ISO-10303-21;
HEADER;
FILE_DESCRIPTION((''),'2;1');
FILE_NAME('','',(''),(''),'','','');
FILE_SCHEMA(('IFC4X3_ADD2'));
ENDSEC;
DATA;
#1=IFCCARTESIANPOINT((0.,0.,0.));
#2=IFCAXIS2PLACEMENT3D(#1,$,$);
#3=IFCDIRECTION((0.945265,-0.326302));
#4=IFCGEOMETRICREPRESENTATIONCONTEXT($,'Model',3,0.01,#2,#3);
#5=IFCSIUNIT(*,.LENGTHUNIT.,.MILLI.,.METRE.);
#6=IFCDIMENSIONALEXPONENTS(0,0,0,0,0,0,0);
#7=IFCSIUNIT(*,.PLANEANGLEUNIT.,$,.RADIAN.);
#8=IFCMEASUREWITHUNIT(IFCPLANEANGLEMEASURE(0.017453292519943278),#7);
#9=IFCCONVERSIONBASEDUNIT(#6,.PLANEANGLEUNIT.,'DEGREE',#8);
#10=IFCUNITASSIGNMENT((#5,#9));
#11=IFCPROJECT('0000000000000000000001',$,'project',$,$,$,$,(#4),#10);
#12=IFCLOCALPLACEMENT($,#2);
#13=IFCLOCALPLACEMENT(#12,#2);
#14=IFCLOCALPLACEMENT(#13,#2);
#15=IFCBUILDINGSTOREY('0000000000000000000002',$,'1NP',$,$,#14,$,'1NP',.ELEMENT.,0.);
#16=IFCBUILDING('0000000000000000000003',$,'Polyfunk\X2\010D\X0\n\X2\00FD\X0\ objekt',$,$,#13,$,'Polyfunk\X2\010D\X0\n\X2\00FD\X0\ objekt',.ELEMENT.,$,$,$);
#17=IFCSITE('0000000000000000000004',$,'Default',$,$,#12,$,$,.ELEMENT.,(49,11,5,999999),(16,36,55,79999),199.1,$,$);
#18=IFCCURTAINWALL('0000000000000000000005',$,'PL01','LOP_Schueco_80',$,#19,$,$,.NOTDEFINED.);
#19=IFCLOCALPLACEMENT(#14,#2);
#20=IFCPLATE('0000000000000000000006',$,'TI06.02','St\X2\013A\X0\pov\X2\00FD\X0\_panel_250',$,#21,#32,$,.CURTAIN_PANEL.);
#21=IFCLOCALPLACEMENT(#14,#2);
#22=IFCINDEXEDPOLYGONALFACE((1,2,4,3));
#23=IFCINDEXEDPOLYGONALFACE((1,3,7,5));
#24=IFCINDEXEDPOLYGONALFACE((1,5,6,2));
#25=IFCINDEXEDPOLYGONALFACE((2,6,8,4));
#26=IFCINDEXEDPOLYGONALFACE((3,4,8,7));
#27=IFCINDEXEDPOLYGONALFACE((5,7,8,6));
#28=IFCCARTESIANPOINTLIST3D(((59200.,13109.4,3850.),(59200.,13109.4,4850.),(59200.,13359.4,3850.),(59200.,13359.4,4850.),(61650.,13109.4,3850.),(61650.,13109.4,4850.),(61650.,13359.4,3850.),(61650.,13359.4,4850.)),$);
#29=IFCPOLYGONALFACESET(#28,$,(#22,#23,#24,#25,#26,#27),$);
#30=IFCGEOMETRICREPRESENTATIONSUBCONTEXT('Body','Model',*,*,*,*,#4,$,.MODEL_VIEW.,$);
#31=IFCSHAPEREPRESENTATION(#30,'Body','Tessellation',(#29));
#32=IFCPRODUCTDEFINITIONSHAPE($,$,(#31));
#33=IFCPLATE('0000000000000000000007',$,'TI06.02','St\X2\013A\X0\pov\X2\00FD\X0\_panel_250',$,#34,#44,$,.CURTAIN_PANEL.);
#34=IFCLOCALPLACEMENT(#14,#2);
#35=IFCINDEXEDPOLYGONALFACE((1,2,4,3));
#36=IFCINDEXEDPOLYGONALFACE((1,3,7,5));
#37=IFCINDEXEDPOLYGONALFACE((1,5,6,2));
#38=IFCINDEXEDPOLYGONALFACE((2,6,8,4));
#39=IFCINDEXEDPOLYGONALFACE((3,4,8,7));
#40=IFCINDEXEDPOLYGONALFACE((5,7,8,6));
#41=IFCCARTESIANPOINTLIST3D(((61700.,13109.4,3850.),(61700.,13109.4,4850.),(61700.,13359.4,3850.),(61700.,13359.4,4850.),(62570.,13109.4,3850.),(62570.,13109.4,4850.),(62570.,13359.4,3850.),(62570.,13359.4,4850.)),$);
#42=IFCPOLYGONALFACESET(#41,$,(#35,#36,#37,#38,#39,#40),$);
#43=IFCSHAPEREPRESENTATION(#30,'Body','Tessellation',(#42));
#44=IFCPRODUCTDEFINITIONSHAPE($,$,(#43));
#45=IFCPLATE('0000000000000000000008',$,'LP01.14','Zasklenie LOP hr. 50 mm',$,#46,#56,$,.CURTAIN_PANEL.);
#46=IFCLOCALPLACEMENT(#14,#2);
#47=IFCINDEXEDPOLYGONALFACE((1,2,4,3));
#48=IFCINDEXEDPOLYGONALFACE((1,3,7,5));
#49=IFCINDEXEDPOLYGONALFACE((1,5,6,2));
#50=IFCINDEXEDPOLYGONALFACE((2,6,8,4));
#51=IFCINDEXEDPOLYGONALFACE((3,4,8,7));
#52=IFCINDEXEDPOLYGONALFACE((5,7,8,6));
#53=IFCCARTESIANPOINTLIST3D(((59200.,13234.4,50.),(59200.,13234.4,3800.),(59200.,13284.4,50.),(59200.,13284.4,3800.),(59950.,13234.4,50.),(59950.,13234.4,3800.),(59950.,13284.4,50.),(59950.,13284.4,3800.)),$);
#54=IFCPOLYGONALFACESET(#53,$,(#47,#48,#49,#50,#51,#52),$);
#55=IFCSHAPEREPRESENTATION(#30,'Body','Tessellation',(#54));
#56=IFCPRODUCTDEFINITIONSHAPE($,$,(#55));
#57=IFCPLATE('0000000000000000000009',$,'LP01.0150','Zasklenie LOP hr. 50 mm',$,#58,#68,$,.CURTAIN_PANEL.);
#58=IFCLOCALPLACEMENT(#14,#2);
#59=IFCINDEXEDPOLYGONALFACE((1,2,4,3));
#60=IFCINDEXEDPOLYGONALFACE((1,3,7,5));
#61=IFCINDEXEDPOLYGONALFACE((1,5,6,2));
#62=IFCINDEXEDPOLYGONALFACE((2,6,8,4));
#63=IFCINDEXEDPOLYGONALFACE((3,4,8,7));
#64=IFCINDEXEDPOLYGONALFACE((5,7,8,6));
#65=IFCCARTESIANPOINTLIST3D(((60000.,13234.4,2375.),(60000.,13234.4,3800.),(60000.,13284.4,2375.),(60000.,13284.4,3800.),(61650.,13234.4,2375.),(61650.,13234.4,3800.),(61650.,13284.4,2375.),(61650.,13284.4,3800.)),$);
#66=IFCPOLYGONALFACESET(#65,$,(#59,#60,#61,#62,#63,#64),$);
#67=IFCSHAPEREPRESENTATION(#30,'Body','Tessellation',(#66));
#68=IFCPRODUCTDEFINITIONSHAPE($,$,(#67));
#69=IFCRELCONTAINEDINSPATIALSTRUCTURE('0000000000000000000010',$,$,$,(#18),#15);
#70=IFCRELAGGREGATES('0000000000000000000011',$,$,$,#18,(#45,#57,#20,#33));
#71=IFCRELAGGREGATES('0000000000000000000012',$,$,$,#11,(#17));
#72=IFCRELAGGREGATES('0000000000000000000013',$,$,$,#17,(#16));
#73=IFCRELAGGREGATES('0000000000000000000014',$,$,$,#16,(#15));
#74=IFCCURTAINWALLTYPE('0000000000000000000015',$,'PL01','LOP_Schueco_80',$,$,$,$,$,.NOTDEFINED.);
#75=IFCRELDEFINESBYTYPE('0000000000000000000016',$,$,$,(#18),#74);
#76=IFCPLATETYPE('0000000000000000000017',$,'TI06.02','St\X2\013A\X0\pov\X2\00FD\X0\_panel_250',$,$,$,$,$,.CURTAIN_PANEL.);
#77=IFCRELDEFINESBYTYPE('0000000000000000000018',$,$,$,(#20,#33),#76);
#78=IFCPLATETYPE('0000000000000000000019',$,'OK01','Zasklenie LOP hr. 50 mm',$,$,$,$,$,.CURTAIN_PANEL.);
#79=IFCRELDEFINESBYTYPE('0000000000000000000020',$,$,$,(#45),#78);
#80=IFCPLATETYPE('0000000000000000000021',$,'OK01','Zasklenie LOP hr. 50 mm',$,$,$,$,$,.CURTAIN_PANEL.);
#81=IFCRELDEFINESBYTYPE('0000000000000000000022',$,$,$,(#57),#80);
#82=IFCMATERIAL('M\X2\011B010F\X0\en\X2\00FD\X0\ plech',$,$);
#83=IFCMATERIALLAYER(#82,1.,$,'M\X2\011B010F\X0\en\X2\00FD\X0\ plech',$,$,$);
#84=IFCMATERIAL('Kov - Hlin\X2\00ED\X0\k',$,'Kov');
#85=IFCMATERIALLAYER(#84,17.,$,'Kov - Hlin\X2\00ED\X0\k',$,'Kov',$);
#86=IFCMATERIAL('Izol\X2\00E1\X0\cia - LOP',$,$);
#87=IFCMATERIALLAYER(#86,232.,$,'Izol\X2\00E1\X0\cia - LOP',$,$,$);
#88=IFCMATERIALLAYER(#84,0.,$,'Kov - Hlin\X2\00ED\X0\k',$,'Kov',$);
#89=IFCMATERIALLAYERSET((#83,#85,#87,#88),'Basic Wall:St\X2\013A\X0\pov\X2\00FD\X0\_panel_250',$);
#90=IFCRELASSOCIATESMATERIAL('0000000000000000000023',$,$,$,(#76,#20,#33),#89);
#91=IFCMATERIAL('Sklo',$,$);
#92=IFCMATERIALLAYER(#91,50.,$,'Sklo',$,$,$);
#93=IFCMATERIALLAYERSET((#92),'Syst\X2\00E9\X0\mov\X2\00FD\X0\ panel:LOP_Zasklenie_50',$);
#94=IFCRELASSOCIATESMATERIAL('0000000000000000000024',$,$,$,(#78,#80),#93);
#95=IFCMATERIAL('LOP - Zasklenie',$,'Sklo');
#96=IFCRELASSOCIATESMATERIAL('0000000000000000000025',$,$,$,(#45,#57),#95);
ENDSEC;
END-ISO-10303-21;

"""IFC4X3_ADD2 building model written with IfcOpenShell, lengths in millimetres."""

from ifc_helpers import new_model, entity, si_unit, converted_unit, direction, frame, frame_2d, origin, origin_2d_with_axis, place, context, subcontext, project, spatial, rectangle, extrude, source, transform, mapped, material, layer, layer_set, layer_usage, type_object, type_shapes, element, aggregate, save


model = new_model("IFC4X3_ADD2")

# Units and contexts
model_context = context("Model", 3, precision=0.01, world=origin(), true_north=direction((0.945265, -0.326302)))
body_context = subcontext(model_context, "Body", "Model", "MODEL_VIEW")
ifc_project = project(units=[si_unit("LENGTHUNIT", "METRE", prefix="MILLI"), converted_unit("PLANEANGLEUNIT", "DEGREE", entity("IfcPlaneAngleMeasure", 0.017453292519943278), si_unit("PLANEANGLEUNIT", "RADIAN"), dimensions=[0, 0, 0, 0, 0, 0, 0])], contexts=[model_context])

# Site, building, storey
site_placement = place(None, origin())
site = spatial("IfcSite", under=ifc_project, at=site_placement, Name="Default", CompositionType="ELEMENT", RefLatitude=(49, 11, 5, 999999), RefLongitude=(16, 36, 55, 79999), RefElevation=199.1)
building_placement = place(site_placement, origin())
building = spatial("IfcBuilding", under=site, at=building_placement, Name="Polyfunkčný objekt", LongName="Polyfunkčný objekt", CompositionType="ELEMENT")
storey_placement = place(building_placement, origin())
storey = spatial("IfcBuildingStorey", under=building, at=storey_placement, Name="1NP", LongName="1NP", CompositionType="ELEMENT", Elevation=0.0)

# Curtain wall, plates
curtain_wall_type = type_object("IfcCurtainWallType", Name="PL01", Description="LOP_Schueco_80", PredefinedType="NOTDEFINED")
curtain_wall_1_placement = place(storey_placement, origin())
curtain_wall_1 = element("IfcCurtainWall", 1, at=curtain_wall_1_placement, inside=storey, type_object=curtain_wall_type, Name="PL01", Description="LOP_Schueco_80", PredefinedType="NOTDEFINED")
ifc_material_1 = material(Name="Měďený plech")
ifc_layer_1 = layer(ifc_material_1, 1.0, Name="Měďený plech")
ifc_material_2 = material(Name="Kov - Hliník", Category="Kov")
ifc_layer_2 = layer(ifc_material_2, 17.0, Name="Kov - Hliník", Category="Kov")
ifc_material_3 = material(Name="Izolácia - LOP")
ifc_layer_3 = layer(ifc_material_3, 232.0, Name="Izolácia - LOP")
ifc_layer_4 = layer(ifc_material_2, 0.0, Name="Kov - Hliník", Category="Kov")
ifc_layer_set_1 = layer_set([ifc_layer_1, ifc_layer_2, ifc_layer_3, ifc_layer_4], Name="Basic Wall:Stĺpový_panel_250")
ifc_layer_usage_1 = layer_usage(ifc_layer_set_1, "AXIS2", "NEGATIVE", 125.0)
plate_type_1 = type_object("IfcPlateType", Name="TI06.02", Description="Stĺpový_panel_250", PredefinedType="CURTAIN_PANEL", material=ifc_layer_set_1)
plate_1_placement = place(storey_placement, frame((59200.0, 13234.4, 3850.0)))
plate_1 = element("IfcPlate", 2, at=plate_1_placement, type_object=plate_type_1, material=ifc_layer_usage_1, Name="TI06.02", Description="Stĺpový_panel_250", PredefinedType="CURTAIN_PANEL", context=body_context, shape_type="SweptSolid", body=[
    extrude(rectangle(XDim=250.0, YDim=2450.0, at=frame_2d((0.0, 0.0), x_axis=(1.0, 0.0))), frame((1225.0, 0.0, 0.0), z_axis=(0.0, 0.0, 1.0), x_axis=(0.0, 1.0, 0.0)), (0.0, 0.0, 1.0), 1000.0),
])
ifc_layer_usage_2 = layer_usage(ifc_layer_set_1, "AXIS2", "NEGATIVE", 125.0)
plate_2_placement = place(storey_placement, frame((61700.0, 13234.4, 3850.0)))
plate_2 = element("IfcPlate", 3, at=plate_2_placement, type_object=plate_type_1, material=ifc_layer_usage_2, Name="TI06.02", Description="Stĺpový_panel_250", PredefinedType="CURTAIN_PANEL", context=body_context, shape_type="SweptSolid", body=[
    extrude(rectangle(XDim=250.0, YDim=870.0, at=frame_2d((0.0, 0.0), x_axis=(1.0, 0.0))), frame((435.0, 0.0, 0.0), z_axis=(0.0, 0.0, 1.0), x_axis=(0.0, 1.0, 0.0)), (0.0, 0.0, 1.0), 1000.0),
])

# Plates
ifc_material_4 = material(Name="LOP - Zasklenie", Category="Sklo")
ifc_material_5 = material(Name="Sklo")
ifc_layer_5 = layer(ifc_material_5, 50.0, Name="Sklo")
ifc_layer_set_2 = layer_set([ifc_layer_5], Name="Systémový panel:LOP_Zasklenie_50")
plate_type_2 = type_object("IfcPlateType", Name="OK01", Description="Zasklenie LOP hr. 50 mm", PredefinedType="CURTAIN_PANEL", material=ifc_layer_set_2)
shared_shape_1 = source(origin(), body_context, "Body", "SweptSolid", [
    extrude(rectangle(XDim=3750.0, YDim=750.0, at=frame_2d((-141.7, 0.0), x_axis=(1.0, 0.0))), frame((0.0, 0.0, 2016.7), z_axis=(0.0, 1.0, 0.0), x_axis=(0.0, 0.0, 1.0)), (0.0, 0.0, 1.0), 50.0),
])
type_shapes(plate_type_2, [shared_shape_1])
plate_3_placement = place(curtain_wall_1_placement, frame((59575.0, 13234.4, 50.0)))
plate_3 = element("IfcPlate", 4, at=plate_3_placement, type_object=plate_type_2, material=ifc_material_4, Name="LP01.14", Description="Zasklenie LOP hr. 50 mm", PredefinedType="CURTAIN_PANEL", context=body_context, shape_type="MappedRepresentation", body=[
    mapped(shared_shape_1, transform((0.0, 0.0, 0.0), scale=1.0)),
])
plate_type_3 = type_object("IfcPlateType", Name="OK01", Description="Zasklenie LOP hr. 50 mm", PredefinedType="CURTAIN_PANEL", material=ifc_layer_set_2)
shared_shape_2 = source(origin(), body_context, "Body", "SweptSolid", [
    extrude(rectangle(XDim=50.0, YDim=1650.0, at=origin_2d_with_axis()), frame((0.0, 25.0, 0.0), z_axis=(0.0, 0.0, 1.0), x_axis=(0.0, 1.0, 0.0)), (0.0, 0.0, 1.0), 1425.0),
])
type_shapes(plate_type_3, [shared_shape_2])
plate_4_placement = place(curtain_wall_1_placement, frame((60825.0, 13234.4, 2375.0)))
plate_4 = element("IfcPlate", 5, at=plate_4_placement, type_object=plate_type_3, material=ifc_material_4, Name="LP01.0150", Description="Zasklenie LOP hr. 50 mm", PredefinedType="CURTAIN_PANEL", context=body_context, shape_type="MappedRepresentation", body=[
    mapped(shared_shape_2, transform((0.0, 0.0, 0.0), scale=1.0)),
])
aggregate(curtain_wall_1, [plate_3, plate_4, plate_1, plate_2])

save(model, "model.ifc")
